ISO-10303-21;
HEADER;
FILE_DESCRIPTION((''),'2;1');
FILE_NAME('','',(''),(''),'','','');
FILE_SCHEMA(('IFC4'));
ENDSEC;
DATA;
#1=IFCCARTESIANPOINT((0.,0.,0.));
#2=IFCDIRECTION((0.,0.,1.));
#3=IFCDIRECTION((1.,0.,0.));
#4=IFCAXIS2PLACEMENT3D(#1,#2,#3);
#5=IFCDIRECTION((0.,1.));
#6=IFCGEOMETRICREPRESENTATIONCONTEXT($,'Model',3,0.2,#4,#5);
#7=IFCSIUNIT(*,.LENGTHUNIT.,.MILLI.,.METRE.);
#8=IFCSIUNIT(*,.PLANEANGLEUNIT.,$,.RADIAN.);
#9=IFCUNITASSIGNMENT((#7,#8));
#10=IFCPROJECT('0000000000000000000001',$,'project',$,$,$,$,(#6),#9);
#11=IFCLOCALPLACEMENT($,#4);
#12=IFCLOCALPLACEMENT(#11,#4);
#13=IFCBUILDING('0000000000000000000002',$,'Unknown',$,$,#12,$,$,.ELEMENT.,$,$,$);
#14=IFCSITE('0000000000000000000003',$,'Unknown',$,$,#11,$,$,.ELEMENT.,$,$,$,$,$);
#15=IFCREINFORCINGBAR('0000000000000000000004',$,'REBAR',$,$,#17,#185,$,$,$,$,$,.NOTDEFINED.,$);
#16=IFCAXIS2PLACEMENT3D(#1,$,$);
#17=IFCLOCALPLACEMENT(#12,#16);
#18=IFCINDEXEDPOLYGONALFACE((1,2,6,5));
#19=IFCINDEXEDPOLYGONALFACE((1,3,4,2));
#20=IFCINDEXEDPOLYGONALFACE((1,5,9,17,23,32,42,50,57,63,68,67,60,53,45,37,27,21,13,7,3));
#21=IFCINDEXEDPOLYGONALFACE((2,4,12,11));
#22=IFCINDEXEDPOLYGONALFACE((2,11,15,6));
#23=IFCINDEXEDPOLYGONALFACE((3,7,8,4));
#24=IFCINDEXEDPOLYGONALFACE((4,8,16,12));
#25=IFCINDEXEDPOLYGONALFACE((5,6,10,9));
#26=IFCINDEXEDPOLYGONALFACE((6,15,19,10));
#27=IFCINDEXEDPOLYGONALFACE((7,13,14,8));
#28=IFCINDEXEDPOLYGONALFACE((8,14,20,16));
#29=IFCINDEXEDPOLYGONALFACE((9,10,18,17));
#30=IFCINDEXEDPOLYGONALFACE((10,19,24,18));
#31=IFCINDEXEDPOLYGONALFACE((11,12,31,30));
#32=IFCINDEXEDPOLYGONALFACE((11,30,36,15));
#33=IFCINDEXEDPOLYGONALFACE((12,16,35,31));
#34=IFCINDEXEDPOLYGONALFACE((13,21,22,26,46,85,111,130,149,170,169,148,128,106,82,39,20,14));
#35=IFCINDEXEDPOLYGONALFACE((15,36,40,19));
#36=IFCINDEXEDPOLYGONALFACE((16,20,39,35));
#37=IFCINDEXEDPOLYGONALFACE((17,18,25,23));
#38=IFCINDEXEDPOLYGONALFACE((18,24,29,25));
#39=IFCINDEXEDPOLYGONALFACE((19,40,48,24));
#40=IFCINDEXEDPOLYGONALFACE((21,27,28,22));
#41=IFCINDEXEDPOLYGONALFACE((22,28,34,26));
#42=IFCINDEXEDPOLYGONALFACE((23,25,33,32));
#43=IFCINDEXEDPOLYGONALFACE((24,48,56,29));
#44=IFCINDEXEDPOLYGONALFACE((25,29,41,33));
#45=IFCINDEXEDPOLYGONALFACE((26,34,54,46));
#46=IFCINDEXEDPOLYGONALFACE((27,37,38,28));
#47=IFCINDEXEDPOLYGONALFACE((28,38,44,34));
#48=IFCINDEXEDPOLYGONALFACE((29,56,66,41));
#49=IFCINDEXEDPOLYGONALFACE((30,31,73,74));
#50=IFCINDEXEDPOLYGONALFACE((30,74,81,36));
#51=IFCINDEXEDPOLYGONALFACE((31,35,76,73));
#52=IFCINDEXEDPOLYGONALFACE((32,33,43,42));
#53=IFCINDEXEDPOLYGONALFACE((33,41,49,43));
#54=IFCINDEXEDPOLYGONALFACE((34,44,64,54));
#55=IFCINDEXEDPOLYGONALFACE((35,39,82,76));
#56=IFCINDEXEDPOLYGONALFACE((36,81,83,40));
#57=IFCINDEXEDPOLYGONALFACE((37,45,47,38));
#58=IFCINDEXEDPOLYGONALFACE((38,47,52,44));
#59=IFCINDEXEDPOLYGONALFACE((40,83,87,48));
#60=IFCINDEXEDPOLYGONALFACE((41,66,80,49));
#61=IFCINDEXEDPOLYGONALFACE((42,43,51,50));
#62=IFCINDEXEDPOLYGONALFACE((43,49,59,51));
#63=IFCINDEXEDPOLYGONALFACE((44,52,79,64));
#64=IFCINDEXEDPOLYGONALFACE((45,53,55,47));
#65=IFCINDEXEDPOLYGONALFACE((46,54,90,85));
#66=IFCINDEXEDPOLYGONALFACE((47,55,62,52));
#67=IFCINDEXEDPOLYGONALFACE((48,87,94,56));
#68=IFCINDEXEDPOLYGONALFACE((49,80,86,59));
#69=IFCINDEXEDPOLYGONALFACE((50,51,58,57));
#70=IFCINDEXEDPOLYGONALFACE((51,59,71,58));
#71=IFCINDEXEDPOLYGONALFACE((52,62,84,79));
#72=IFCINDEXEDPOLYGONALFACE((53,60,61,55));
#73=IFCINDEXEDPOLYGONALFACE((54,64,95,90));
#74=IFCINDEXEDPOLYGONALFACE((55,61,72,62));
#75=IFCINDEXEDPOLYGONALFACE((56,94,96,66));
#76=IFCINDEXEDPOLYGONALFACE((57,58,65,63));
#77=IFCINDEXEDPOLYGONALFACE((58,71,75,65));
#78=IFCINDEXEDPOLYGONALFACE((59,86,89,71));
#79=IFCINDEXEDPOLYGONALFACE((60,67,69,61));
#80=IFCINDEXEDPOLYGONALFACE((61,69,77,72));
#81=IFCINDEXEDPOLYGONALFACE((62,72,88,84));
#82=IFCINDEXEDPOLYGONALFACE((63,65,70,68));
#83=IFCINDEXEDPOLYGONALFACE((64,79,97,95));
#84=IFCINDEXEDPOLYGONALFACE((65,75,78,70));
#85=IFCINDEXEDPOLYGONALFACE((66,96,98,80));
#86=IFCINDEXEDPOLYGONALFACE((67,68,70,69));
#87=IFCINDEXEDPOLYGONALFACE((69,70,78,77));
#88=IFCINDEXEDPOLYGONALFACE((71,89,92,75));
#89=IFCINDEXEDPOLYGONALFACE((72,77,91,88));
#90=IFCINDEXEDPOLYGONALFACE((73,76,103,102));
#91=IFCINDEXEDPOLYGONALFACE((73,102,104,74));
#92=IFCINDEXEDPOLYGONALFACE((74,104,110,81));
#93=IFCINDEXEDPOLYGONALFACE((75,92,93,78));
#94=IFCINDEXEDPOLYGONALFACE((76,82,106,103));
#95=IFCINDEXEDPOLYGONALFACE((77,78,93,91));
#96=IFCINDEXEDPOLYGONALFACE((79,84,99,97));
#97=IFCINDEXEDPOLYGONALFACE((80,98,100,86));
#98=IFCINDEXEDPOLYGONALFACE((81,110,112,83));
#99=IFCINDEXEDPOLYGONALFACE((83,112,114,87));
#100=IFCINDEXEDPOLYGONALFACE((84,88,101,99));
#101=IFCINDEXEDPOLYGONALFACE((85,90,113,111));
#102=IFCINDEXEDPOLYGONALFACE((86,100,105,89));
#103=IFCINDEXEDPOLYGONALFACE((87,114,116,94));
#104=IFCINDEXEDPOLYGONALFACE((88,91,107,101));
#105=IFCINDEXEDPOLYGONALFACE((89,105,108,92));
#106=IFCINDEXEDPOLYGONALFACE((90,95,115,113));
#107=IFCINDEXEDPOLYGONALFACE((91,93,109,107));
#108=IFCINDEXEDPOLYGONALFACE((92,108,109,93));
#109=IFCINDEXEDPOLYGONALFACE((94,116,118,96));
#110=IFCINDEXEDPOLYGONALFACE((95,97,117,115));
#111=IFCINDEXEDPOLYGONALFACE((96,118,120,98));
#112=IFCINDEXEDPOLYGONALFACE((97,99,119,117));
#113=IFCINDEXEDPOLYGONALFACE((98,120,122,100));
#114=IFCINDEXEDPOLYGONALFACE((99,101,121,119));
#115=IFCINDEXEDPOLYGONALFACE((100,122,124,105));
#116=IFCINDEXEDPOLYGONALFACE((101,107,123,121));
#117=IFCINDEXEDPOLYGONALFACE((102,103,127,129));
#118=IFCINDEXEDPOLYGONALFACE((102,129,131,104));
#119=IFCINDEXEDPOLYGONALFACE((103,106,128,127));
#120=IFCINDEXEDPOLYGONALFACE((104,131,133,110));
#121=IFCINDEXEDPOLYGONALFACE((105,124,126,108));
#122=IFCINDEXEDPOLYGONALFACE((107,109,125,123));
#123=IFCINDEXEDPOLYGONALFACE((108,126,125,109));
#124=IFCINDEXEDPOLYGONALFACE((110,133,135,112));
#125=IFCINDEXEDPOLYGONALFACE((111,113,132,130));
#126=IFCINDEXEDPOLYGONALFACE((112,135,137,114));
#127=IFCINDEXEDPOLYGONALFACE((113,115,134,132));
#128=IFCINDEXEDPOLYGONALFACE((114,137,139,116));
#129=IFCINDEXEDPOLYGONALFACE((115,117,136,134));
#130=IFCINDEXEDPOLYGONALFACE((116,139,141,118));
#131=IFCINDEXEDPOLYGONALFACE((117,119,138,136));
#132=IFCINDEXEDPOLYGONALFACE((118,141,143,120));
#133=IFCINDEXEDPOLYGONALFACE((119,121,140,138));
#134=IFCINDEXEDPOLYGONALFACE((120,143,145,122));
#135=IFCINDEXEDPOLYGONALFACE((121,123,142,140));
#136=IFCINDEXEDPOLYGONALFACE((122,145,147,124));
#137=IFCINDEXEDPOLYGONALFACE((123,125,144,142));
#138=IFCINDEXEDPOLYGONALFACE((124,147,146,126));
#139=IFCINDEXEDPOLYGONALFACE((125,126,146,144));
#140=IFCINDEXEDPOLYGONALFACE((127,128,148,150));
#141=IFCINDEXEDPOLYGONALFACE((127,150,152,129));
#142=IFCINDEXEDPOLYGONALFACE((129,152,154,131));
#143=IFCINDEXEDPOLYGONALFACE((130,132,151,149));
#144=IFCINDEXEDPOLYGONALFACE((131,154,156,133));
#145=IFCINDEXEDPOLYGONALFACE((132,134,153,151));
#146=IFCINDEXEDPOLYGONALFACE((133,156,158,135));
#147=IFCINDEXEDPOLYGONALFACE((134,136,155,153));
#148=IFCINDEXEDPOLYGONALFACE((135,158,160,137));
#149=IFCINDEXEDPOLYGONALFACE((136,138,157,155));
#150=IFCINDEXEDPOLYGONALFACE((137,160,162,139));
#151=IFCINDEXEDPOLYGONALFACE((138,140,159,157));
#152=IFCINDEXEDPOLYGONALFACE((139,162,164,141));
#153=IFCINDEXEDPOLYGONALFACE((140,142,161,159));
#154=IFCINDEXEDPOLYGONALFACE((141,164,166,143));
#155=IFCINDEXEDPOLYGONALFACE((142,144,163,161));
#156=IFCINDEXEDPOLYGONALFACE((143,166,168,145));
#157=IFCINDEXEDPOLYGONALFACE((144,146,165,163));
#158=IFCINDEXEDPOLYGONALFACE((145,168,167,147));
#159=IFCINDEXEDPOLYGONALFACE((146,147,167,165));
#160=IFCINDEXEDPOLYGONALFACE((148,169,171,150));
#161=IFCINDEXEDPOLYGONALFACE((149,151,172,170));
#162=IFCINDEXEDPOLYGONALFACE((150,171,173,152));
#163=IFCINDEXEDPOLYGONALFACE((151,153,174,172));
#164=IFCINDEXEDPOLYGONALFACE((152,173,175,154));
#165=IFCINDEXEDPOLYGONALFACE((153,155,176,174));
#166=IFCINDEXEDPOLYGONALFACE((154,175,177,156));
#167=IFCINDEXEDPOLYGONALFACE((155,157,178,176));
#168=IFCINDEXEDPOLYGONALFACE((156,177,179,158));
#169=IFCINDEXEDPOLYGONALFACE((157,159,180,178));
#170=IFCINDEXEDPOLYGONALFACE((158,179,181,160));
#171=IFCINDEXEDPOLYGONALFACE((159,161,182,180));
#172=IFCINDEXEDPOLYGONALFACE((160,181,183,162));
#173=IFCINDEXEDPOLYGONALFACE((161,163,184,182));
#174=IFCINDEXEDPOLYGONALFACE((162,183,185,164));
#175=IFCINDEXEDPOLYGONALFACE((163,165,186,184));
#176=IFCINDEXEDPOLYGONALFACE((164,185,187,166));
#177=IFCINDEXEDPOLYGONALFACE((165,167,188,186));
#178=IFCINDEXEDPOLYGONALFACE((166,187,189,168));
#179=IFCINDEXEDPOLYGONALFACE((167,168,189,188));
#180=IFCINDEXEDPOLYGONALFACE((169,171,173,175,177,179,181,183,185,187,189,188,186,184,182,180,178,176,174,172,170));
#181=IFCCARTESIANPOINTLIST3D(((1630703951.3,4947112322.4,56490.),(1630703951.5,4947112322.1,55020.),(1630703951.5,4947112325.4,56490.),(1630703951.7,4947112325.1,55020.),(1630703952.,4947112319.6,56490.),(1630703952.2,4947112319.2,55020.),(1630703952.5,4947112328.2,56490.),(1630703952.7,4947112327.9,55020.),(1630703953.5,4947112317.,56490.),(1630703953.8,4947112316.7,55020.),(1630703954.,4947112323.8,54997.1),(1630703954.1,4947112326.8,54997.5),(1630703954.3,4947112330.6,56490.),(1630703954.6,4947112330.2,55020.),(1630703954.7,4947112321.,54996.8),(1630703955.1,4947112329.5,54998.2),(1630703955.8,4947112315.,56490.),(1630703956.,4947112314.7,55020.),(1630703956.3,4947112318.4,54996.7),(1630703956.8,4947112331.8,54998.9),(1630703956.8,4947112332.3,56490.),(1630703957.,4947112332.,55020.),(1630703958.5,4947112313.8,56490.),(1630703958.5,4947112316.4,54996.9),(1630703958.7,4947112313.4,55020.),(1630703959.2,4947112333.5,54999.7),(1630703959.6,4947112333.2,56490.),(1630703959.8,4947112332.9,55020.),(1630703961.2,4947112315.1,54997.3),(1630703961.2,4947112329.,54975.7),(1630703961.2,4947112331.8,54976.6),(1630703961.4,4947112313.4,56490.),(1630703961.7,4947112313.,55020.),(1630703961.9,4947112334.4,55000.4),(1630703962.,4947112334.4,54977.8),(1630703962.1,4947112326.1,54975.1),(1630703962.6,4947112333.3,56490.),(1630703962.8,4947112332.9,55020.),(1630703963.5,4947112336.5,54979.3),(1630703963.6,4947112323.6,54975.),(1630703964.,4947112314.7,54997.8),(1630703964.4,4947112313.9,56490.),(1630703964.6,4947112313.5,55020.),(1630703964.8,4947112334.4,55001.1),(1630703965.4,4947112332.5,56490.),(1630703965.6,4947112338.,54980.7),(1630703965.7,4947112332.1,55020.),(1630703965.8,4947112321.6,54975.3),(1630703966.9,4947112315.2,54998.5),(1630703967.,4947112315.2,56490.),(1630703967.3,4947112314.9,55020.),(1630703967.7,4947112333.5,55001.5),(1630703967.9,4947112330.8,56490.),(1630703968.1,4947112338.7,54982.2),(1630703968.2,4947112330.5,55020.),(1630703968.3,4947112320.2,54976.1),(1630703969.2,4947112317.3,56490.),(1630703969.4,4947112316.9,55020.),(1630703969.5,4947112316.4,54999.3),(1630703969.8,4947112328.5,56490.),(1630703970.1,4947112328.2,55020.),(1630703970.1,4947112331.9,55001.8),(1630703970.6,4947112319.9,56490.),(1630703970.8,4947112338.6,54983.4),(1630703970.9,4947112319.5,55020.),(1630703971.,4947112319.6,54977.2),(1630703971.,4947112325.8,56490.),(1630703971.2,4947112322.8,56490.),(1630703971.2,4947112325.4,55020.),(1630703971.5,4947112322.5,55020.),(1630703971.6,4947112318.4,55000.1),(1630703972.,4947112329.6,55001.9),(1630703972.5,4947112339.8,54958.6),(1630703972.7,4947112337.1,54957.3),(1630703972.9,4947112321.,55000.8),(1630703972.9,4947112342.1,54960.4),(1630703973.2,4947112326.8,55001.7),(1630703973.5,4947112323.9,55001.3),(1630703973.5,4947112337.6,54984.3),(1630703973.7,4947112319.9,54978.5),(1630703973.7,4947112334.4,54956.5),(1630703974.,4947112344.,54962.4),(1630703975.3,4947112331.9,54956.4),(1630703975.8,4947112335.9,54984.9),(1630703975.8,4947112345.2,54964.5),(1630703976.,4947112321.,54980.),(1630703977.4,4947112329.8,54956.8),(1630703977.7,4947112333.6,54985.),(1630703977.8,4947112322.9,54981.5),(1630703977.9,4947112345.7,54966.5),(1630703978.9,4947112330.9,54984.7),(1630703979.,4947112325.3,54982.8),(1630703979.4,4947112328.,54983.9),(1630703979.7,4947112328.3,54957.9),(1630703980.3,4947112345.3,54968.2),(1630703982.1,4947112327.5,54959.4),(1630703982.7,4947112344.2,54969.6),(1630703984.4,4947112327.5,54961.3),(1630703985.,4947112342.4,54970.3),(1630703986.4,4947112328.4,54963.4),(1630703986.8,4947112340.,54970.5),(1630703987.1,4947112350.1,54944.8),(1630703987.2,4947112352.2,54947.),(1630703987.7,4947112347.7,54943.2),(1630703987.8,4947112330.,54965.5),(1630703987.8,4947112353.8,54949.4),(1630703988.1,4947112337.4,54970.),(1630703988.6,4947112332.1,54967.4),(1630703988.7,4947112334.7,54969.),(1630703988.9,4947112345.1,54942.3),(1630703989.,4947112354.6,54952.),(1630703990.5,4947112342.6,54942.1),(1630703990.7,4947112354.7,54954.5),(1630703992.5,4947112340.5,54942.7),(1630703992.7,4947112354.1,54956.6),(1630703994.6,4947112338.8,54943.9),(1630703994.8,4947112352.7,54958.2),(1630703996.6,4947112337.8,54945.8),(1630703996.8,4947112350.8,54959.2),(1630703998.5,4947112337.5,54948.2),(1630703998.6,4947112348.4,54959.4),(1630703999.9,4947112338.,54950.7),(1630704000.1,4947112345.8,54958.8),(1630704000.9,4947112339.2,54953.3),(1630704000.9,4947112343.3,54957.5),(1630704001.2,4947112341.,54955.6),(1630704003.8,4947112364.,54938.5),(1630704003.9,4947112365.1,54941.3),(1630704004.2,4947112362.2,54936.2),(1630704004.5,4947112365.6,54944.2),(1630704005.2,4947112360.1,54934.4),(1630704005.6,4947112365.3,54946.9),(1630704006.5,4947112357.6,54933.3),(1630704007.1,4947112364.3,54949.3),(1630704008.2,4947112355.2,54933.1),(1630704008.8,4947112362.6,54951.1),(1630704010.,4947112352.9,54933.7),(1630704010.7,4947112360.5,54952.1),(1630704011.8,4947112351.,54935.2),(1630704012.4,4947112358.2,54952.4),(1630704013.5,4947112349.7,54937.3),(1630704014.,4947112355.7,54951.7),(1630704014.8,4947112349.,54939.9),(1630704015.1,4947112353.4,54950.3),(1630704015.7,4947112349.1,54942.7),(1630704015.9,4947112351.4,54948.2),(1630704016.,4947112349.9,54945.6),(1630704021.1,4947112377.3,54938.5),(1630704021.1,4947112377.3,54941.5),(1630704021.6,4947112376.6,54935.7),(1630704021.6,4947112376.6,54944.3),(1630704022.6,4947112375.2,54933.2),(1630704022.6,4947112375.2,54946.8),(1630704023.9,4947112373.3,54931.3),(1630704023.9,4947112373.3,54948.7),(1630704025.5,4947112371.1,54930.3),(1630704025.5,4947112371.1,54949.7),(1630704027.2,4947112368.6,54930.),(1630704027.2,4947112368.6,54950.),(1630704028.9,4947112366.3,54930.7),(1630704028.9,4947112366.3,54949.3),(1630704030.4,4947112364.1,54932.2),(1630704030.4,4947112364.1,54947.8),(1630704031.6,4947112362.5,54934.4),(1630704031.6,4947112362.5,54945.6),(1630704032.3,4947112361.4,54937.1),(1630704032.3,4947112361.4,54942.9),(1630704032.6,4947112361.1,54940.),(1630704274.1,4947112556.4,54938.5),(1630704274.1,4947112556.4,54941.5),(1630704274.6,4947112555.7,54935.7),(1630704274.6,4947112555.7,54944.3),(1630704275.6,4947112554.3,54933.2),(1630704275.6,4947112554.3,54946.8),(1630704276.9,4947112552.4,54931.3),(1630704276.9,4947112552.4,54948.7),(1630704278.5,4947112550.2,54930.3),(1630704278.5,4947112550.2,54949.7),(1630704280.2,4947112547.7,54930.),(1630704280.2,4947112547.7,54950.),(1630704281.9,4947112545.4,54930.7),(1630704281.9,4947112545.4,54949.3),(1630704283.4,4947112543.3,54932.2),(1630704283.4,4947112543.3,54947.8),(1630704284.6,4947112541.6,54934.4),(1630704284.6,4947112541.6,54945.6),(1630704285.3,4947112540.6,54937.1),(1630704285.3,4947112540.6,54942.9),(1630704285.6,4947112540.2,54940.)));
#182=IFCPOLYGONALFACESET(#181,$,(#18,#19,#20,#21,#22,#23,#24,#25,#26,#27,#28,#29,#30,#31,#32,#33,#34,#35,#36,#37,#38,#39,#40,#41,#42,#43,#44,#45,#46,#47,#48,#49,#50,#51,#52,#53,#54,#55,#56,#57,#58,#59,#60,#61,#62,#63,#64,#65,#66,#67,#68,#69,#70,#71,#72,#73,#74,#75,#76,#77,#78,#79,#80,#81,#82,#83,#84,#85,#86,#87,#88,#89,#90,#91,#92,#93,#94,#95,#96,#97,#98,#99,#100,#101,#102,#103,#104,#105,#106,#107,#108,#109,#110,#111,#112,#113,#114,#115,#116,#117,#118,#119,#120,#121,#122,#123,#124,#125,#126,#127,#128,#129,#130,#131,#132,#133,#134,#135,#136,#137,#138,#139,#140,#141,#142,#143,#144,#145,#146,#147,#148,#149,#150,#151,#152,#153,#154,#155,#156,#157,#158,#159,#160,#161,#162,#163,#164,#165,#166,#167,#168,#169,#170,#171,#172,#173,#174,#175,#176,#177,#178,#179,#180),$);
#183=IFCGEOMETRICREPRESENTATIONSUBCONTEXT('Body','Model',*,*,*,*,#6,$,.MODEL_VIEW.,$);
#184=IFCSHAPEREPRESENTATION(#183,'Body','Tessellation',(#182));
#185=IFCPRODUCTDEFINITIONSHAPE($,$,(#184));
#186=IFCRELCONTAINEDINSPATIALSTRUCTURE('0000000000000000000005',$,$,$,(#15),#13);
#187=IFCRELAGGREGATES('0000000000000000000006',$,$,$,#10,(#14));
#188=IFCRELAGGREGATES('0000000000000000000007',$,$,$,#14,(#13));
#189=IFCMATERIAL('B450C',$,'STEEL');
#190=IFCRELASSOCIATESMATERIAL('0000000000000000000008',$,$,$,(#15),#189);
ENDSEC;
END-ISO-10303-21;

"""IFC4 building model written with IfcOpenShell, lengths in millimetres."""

from ifc_helpers import new_model, entity, si_unit, direction, frame, origin_with_axes, place, context, subcontext, project, spatial, material, element, save


model = new_model("IFC4")

# Units and contexts
model_context = context("Model", 3, precision=0.2, world=origin_with_axes(), true_north=direction((0.0, 1.0)))
body_context = subcontext(model_context, "Body", "Model", "MODEL_VIEW")
ifc_project = project(units=[si_unit("LENGTHUNIT", "METRE", prefix="MILLI"), si_unit("PLANEANGLEUNIT", "RADIAN")], contexts=[model_context])

# Site, building
site_placement = place(None, origin_with_axes())
site = spatial("IfcSite", under=ifc_project, at=site_placement, Name="Unknown", CompositionType="ELEMENT")
building_placement = place(site_placement, origin_with_axes())
building = spatial("IfcBuilding", under=site, at=building_placement, Name="Unknown", CompositionType="ELEMENT")

# Reinforcing bar
ifc_material = material(Name="B450C", Category="STEEL")
reinforcing_bar_1_placement = place(building_placement, frame((1630703891.8, 4947112334.9, 54890.0), z_axis=(0.5781, -0.815966, 0.0), x_axis=(0.0, 0.0, 1.0)))
element("IfcReinforcingBar", 1, at=reinforcing_bar_1_placement, inside=building, material=ifc_material, Name="REBAR", PredefinedType="NOTDEFINED", context=body_context, shape_type="AdvancedSweptSolid", body=[
    entity("IfcSweptDiskSolid", entity("IfcIndexedPolyCurve", entity("IfcCartesianPointList3D", [[50.0, -440.0, 50.1], [50.0, -130.0, 50.0], [73.4, -73.4, 50.0], [130.0, -50.0, 50.0], [1600.0, -50.0, 49.6]]), [entity("IfcLineIndex", [1, 2]), entity("IfcArcIndex", [2, 3, 4]), entity("IfcLineIndex", [4, 5])]), 10.0),
])

save(model, "model.ifc")
